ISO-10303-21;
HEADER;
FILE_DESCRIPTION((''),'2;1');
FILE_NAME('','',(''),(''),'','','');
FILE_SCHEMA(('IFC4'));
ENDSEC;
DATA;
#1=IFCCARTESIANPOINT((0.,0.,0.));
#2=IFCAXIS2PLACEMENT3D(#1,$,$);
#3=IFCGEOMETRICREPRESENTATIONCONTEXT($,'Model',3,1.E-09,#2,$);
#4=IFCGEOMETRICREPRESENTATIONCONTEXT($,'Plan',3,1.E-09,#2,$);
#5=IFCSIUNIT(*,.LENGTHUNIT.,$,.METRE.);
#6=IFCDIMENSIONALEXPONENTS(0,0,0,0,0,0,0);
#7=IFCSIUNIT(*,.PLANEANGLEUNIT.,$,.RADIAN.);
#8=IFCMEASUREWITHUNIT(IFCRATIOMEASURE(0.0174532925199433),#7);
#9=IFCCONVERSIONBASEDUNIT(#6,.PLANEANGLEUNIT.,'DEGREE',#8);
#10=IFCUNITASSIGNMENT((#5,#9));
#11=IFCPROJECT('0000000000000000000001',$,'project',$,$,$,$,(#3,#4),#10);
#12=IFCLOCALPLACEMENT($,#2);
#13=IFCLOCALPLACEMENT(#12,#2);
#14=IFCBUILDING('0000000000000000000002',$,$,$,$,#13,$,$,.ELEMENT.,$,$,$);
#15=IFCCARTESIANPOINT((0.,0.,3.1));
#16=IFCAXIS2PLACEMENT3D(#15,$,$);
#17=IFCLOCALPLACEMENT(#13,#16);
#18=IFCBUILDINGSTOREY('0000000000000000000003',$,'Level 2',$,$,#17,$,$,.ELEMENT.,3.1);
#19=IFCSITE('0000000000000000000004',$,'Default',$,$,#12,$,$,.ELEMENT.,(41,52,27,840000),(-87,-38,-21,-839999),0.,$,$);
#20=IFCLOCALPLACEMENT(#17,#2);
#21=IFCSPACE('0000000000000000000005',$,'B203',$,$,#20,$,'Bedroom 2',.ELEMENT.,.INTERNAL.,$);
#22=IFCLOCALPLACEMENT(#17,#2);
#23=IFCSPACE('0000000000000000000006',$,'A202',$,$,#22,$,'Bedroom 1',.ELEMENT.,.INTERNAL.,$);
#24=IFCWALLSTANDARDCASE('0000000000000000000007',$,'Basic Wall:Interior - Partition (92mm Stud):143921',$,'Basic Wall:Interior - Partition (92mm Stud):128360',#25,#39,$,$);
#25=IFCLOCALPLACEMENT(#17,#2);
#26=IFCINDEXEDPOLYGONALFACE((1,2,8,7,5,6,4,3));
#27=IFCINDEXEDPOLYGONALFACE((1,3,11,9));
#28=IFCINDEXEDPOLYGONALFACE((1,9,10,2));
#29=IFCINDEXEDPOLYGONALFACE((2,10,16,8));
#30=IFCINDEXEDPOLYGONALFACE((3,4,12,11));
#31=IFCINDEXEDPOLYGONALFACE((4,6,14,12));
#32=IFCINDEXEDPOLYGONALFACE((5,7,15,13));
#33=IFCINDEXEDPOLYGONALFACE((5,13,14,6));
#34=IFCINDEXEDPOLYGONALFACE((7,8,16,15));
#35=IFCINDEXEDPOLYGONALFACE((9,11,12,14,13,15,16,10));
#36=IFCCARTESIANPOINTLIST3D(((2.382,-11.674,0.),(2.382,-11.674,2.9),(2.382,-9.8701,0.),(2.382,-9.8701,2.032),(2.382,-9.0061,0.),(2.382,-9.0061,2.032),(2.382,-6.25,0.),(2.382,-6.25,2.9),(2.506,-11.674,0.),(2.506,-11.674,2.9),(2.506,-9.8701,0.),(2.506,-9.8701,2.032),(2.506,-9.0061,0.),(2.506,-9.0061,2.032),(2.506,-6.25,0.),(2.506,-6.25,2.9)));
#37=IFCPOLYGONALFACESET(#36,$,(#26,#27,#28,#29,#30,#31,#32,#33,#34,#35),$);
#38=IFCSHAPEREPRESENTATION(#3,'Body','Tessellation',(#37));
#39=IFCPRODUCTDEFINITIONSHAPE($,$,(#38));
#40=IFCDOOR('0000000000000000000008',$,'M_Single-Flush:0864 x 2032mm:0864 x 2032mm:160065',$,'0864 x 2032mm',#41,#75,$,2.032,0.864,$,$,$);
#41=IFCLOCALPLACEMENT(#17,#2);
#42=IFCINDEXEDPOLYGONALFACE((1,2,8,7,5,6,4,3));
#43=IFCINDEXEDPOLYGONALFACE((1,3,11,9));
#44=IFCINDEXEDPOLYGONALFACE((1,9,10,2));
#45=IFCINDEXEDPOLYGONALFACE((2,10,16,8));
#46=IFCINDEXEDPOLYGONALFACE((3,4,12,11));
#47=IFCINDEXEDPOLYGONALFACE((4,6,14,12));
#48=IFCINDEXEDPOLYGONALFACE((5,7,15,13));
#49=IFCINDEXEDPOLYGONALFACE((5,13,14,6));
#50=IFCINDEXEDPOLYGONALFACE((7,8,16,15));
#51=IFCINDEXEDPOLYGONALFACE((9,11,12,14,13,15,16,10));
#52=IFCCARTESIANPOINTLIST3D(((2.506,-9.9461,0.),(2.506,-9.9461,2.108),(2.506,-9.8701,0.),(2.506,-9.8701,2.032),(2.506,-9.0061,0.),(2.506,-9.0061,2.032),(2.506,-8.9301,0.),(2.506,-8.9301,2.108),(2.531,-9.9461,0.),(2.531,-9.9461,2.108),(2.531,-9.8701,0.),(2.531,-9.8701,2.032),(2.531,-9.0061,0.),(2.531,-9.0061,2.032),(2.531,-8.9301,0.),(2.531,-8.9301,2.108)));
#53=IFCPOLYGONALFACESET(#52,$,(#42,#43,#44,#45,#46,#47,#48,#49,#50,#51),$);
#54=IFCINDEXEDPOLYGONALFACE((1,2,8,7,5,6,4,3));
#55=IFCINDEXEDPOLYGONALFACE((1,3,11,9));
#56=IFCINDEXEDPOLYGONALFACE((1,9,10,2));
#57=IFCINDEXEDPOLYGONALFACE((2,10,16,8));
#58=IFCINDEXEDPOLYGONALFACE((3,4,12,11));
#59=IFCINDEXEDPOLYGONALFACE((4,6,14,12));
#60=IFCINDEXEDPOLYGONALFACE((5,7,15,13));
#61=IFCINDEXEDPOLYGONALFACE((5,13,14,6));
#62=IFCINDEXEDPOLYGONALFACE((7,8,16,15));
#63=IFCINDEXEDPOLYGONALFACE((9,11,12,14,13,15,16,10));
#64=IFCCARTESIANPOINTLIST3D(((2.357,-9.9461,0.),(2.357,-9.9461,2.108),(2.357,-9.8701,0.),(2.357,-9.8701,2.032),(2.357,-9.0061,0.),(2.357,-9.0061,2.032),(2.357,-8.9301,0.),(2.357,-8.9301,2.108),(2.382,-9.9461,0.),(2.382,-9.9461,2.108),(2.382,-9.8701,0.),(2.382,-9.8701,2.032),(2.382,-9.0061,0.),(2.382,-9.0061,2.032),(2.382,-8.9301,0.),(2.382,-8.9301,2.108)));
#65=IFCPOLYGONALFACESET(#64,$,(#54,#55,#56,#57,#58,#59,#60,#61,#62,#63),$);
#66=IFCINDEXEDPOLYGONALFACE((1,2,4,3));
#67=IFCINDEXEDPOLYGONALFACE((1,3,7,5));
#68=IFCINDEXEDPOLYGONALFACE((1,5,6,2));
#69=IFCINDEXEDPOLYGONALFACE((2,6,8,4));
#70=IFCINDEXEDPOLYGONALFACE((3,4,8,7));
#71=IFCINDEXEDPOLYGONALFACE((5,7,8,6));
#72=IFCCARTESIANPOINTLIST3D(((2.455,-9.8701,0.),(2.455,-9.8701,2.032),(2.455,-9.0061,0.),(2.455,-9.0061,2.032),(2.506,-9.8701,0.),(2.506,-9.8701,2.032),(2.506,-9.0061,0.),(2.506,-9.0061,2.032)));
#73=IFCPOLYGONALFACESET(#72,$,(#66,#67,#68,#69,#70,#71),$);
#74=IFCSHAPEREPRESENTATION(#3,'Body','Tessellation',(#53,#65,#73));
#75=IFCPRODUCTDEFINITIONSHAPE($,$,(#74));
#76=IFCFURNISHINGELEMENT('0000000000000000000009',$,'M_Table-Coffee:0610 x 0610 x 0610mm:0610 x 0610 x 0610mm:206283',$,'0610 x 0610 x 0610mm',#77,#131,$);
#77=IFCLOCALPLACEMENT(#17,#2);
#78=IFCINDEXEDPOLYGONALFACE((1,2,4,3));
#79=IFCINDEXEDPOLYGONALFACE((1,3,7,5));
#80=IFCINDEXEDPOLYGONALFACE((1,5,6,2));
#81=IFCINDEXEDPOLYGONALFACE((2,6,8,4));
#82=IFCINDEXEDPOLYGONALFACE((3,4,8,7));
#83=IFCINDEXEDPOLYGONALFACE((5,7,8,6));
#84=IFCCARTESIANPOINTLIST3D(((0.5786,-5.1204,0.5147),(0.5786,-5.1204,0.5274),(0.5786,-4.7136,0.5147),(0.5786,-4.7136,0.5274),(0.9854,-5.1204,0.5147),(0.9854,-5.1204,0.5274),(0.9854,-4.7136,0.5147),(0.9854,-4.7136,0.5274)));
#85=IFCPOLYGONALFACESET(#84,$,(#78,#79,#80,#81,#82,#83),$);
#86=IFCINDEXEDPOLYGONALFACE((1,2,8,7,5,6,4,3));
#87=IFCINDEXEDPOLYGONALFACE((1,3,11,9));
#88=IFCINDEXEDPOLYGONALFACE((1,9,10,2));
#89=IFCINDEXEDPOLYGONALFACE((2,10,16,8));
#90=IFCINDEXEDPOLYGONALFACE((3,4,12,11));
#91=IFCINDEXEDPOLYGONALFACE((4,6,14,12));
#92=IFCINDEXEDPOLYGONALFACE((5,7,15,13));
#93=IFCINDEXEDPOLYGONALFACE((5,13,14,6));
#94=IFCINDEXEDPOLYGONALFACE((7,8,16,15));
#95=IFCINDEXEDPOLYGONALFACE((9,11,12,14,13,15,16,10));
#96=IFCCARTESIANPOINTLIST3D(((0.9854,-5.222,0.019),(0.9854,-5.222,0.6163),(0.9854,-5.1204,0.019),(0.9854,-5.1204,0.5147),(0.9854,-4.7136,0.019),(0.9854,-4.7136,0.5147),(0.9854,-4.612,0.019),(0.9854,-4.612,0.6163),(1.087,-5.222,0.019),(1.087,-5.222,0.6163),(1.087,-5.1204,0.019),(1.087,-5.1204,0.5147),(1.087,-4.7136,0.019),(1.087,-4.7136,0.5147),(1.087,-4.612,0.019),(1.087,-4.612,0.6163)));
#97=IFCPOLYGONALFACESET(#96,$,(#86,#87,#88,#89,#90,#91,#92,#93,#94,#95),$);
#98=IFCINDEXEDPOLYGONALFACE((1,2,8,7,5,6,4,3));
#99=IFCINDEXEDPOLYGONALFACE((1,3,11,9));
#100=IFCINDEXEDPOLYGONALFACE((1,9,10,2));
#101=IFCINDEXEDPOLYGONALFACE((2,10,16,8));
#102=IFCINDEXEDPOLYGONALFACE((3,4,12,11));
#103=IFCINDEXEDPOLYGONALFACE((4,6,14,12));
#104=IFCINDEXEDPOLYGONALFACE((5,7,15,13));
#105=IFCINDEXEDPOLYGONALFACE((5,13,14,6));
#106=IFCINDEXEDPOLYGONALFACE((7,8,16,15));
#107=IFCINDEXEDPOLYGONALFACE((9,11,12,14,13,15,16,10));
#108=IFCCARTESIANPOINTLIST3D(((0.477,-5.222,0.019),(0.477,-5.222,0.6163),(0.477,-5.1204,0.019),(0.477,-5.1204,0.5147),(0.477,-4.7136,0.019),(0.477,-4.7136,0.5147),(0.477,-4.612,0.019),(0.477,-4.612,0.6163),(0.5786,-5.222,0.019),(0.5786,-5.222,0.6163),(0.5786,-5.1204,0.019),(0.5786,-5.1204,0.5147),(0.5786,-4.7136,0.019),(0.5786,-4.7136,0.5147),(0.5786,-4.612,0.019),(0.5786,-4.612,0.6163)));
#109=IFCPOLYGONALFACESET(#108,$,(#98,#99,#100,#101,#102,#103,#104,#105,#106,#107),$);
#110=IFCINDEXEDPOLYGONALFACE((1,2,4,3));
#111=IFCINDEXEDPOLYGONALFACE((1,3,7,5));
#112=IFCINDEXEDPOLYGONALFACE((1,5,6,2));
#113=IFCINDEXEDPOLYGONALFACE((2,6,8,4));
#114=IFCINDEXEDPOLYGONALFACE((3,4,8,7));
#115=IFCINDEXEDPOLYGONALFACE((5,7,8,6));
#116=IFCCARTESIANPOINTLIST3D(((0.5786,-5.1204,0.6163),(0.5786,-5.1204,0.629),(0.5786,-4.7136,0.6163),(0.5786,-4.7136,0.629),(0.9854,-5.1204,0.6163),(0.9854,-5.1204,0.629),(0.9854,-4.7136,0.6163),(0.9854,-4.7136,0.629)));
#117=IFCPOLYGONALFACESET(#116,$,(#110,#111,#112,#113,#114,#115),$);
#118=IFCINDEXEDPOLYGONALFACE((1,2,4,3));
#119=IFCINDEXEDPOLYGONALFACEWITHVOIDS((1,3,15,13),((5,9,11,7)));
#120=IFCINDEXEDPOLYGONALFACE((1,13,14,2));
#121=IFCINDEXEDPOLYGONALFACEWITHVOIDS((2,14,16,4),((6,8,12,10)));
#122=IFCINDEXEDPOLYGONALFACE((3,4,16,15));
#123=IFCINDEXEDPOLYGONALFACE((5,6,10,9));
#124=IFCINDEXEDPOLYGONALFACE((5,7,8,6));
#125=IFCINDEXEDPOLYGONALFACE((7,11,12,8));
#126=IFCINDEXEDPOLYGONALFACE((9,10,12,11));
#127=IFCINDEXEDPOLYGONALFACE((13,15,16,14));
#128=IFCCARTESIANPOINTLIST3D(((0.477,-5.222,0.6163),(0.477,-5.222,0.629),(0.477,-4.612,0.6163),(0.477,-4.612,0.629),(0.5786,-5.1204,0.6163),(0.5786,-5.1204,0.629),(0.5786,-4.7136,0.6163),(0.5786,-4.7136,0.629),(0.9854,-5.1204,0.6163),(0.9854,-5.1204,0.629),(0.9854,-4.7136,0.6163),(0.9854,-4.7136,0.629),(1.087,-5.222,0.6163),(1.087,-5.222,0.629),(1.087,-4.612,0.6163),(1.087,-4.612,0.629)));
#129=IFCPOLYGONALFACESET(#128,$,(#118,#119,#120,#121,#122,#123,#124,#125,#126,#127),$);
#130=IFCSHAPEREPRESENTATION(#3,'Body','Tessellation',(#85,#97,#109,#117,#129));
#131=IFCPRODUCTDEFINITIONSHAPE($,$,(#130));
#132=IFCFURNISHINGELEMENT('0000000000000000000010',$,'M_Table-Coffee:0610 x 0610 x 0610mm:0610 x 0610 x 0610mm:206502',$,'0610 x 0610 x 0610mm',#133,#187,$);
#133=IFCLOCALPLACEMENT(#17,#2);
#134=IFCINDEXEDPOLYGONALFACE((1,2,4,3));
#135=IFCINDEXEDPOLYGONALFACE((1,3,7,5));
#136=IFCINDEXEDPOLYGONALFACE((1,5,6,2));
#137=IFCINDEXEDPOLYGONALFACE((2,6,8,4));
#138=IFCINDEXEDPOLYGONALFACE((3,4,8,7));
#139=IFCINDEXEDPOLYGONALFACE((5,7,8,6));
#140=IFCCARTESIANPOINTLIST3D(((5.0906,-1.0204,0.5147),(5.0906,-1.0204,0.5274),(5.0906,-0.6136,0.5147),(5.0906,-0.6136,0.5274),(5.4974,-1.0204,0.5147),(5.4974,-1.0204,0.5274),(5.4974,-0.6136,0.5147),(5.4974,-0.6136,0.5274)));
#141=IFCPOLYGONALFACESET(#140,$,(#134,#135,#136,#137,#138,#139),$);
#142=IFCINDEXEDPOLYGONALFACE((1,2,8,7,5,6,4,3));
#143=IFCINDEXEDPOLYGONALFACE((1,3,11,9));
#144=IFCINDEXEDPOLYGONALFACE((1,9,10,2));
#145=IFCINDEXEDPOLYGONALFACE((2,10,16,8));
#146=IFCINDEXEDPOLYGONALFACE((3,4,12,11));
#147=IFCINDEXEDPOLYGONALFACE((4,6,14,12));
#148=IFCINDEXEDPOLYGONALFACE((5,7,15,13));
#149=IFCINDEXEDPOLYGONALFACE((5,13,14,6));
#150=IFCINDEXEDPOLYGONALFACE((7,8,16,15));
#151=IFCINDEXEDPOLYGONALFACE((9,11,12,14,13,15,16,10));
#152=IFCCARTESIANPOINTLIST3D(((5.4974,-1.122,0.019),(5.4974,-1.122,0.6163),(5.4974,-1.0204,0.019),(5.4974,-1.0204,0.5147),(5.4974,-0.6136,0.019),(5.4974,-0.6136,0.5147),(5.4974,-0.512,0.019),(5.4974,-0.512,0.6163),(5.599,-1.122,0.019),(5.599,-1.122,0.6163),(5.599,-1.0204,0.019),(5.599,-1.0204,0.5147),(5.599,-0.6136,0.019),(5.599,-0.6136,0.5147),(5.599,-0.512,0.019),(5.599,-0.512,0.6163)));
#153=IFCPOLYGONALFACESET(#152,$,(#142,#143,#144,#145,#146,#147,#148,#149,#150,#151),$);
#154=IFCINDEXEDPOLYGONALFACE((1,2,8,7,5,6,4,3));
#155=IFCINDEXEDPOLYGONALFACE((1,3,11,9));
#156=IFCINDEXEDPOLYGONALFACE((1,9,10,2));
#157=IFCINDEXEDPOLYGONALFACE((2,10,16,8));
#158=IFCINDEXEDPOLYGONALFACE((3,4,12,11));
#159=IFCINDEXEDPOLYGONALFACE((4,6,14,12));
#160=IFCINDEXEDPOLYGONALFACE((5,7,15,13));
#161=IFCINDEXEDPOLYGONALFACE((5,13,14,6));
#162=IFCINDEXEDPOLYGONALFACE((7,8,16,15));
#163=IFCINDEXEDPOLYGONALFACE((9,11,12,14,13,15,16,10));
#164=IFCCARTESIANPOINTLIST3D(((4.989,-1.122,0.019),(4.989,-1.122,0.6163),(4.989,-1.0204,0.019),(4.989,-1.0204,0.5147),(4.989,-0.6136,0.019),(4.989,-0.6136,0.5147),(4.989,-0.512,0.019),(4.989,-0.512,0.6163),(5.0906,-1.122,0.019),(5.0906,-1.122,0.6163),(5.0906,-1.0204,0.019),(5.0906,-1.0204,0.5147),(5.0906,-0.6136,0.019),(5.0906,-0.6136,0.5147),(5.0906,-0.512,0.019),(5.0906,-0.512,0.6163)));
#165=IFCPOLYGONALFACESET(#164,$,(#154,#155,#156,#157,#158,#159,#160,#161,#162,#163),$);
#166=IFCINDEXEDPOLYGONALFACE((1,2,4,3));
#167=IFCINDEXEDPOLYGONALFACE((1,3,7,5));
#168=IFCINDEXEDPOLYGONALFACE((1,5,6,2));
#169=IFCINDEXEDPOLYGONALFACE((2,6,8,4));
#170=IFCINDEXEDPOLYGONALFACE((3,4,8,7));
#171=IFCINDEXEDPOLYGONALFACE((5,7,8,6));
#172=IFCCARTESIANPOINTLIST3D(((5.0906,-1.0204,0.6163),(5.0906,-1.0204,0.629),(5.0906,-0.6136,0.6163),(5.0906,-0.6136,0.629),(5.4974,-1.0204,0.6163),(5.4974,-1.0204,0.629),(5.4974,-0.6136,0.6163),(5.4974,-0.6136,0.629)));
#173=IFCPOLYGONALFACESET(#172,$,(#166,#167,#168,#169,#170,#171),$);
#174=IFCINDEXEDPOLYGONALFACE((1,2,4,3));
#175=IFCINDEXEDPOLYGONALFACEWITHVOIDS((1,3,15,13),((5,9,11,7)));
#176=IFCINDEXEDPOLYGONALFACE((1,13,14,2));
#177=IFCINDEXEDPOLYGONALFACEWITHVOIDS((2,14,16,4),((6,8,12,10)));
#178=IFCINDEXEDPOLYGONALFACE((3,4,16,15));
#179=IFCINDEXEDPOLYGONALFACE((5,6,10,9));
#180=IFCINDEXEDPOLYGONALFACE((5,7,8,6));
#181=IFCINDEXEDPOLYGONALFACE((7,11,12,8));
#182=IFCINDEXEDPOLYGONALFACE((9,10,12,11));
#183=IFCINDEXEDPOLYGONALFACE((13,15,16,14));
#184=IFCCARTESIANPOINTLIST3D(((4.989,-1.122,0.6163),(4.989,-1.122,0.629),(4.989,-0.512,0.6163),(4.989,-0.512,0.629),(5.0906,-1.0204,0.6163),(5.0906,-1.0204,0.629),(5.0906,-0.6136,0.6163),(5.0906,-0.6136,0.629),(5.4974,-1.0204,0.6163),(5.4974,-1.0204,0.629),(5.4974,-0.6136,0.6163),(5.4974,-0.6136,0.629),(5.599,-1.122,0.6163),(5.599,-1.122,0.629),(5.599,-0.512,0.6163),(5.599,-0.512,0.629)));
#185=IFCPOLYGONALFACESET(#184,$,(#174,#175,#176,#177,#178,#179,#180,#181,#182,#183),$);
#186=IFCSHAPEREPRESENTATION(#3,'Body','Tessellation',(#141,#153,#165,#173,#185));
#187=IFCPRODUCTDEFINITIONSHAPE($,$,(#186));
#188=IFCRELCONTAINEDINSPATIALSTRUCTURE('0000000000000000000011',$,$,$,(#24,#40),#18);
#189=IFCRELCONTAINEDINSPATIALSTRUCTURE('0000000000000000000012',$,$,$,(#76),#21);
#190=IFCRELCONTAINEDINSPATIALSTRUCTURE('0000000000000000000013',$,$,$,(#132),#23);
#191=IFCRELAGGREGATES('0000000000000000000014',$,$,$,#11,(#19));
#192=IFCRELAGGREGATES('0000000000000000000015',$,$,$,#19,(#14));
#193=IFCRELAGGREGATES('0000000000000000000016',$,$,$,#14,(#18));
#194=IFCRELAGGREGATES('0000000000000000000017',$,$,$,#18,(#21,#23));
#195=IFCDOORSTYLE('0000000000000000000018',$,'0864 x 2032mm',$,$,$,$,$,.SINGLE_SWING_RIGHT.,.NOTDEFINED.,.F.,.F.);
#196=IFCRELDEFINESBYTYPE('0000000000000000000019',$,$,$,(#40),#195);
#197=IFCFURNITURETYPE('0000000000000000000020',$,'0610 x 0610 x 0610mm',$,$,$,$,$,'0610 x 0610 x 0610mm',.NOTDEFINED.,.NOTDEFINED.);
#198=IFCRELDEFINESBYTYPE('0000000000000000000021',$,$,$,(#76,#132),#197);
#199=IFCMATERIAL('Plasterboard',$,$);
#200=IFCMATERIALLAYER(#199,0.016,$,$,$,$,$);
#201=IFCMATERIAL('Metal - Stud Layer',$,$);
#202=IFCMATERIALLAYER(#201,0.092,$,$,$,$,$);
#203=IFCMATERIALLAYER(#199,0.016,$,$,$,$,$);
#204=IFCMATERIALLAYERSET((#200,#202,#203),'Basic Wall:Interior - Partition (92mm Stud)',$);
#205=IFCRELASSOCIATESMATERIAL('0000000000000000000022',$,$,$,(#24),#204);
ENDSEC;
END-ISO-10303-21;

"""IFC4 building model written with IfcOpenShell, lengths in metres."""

from ifc_helpers import new_model, entity, si_unit, converted_unit, frame, frame_2d, origin, origin_2d_with_axis, place, context, project, spatial, polyline, rectangle, outline, extrude, source, transform, mapped, material, layer, layer_set, layer_usage, type_object, type_shapes, element, fill, save


model = new_model("IFC4")

# Units and contexts
model_context = context("Model", 3, precision=1e-09, world=origin())
plan_context = context("Plan", 3, precision=1e-09, world=origin())
ifc_project = project(units=[si_unit("LENGTHUNIT", "METRE"), converted_unit("PLANEANGLEUNIT", "DEGREE", entity("IfcRatioMeasure", 0.0174532925199433), si_unit("PLANEANGLEUNIT", "RADIAN"), dimensions=[0, 0, 0, 0, 0, 0, 0])], contexts=[model_context, plan_context])

# Site, building, storey
site_placement = place(None, origin())
site = spatial("IfcSite", under=ifc_project, at=site_placement, Name="Default", CompositionType="ELEMENT", RefLatitude=(41, 52, 27, 840000), RefLongitude=(-87, -38, -21, -839999), RefElevation=0.0)
building_placement = place(site_placement, origin())
building = spatial("IfcBuilding", under=site, at=building_placement, CompositionType="ELEMENT")
storey_placement = place(building_placement, frame((0.0, 0.0, 3.1)))
storey = spatial("IfcBuildingStorey", under=building, at=storey_placement, Name="Level 2", CompositionType="ELEMENT", Elevation=3.1)

# Shared definitions
ifc_material_1 = material(Name="Metal - Stud Layer")
ifc_material_2 = material(Name="Plasterboard")

# Wall, opening, door
ifc_layer_1 = layer(ifc_material_2, 0.016)
ifc_layer_2 = layer(ifc_material_1, 0.092)
ifc_layer_3 = layer(ifc_material_2, 0.016)
ifc_layer_set_1 = layer_set([ifc_layer_1, ifc_layer_2, ifc_layer_3], Name="Basic Wall:Interior - Partition (92mm Stud)")
ifc_layer_usage_1 = layer_usage(ifc_layer_set_1, "AXIS2", "NEGATIVE", 0.062)
wall_1_placement = place(storey_placement, frame((2.444, -6.25, 0.0), z_axis=(0.0, 0.0, 1.0), x_axis=(0.0, -1.0, 0.0)))
wall_1 = element("IfcWallStandardCase", 1, at=wall_1_placement, inside=storey, material=ifc_layer_usage_1, Name="Basic Wall:Interior - Partition (92mm Stud):143921", ObjectType="Basic Wall:Interior - Partition (92mm Stud):128360", context=model_context, shape_type="SweptSolid", body=[
    extrude(rectangle(XDim=5.424, YDim=0.124, at=frame_2d((2.712, 0.0), x_axis=(-1.0, 0.0))), origin(), (0.0, 0.0, 1.0), 2.9),
])
opening_1_placement = place(wall_1_placement, frame((2.7561, -0.062, 0.0)))
opening_1 = element("IfcOpeningElement", 2, at=opening_1_placement, cuts=wall_1, ObjectType="Opening", context=model_context, shape_type="SweptSolid", body=[
    extrude(rectangle(XDim=0.864, YDim=2.032, at=frame_2d((1.016, 0.432), x_axis=(0.0, 1.0))), frame((0.0, 0.0, 0.0), z_axis=(0.0, 1.0, 0.0), x_axis=(0.0, 0.0, 1.0)), (0.0, 0.0, 1.0), 0.124),
])
door_style_1 = type_object("IfcDoorStyle", Name="0864 x 2032mm", ConstructionType="NOTDEFINED", OperationType="SINGLE_SWING_RIGHT", ParameterTakesPrecedence=False, Sizeable=False)
shared_shape_1 = source(origin(), model_context, "Body", "SweptSolid", [
    extrude(outline(polyline([(-0.508, -1.073), (0.508, -1.073), (0.508, 1.035), (0.432, 1.035), (0.432, -0.997), (-0.432, -0.997), (-0.432, 1.035), (-0.508, 1.035), (-0.508, -1.073)])), frame((0.432, 0.124, 1.035), z_axis=(0.0, 1.0, 0.0), x_axis=(1.0, 0.0, 0.0)), (0.0, 0.0, 1.0), 0.025),
    extrude(outline(polyline([(-1.073, -0.508), (1.035, -0.508), (1.035, -0.432), (-0.997, -0.432), (-0.997, 0.432), (1.035, 0.432), (1.035, 0.508), (-1.073, 0.508), (-1.073, -0.508)])), frame((0.432, -0.025, 1.035), z_axis=(0.0, 1.0, 0.0), x_axis=(0.0, 0.0, -1.0)), (0.0, 0.0, 1.0), 0.025),
    extrude(rectangle(XDim=0.051, YDim=0.864, at=origin_2d_with_axis()), frame((0.432, 0.0985, 0.0), z_axis=(0.0, 0.0, 1.0), x_axis=(0.0, 1.0, 0.0)), (0.0, 0.0, 1.0), 2.032),
])
type_shapes(door_style_1, [shared_shape_1])
door_1_placement = place(opening_1_placement, origin())
door_1 = element("IfcDoor", 3, at=door_1_placement, inside=storey, type_object=door_style_1, Name="M_Single-Flush:0864 x 2032mm:0864 x 2032mm:160065", ObjectType="0864 x 2032mm", OverallHeight=2.032, OverallWidth=0.864, context=model_context, shape_type="MappedRepresentation", body=[
    mapped(shared_shape_1, transform((0.0, 0.0, 0.0), scale=1.0)),
])
fill(opening_1, door_1)

# Shared definitions
space_1_placement = place(storey_placement, origin())
space_1 = spatial("IfcSpace", under=storey, at=space_1_placement, Name="B203", LongName="Bedroom 2", CompositionType="ELEMENT", PredefinedType="INTERNAL")

# Furnishing element
furniture_type = type_object("IfcFurnitureType", Name="0610 x 0610 x 0610mm", ElementType="0610 x 0610 x 0610mm", AssemblyPlace="NOTDEFINED")
shared_shape_2 = source(origin(), model_context, "Body", "SweptSolid", [
    extrude(rectangle(XDim=0.4068, YDim=0.4068, at=origin_2d_with_axis()), frame((0.0183, 0.0952, 0.4957), z_axis=(0.0, 0.0, 1.0), x_axis=(-1.0, 0.0, 0.0)), (0.0, 0.0, 1.0), 0.0127),
    extrude(outline(polyline([(-0.2732, -0.305), (0.324, -0.305), (0.324, 0.305), (-0.2732, 0.305), (-0.2732, 0.2034), (0.2225, 0.2034), (0.2225, -0.2034), (-0.2732, -0.2034), (-0.2732, -0.305)])), frame((0.2217, 0.0952, 0.2732), z_axis=(1.0, 0.0, 0.0), x_axis=(0.0, 0.0, 1.0)), (0.0, 0.0, 1.0), 0.1016),
    extrude(outline(polyline([(-0.305, -0.3241), (0.305, -0.3241), (0.305, 0.2733), (0.2034, 0.2733), (0.2034, -0.2224), (-0.2034, -0.2224), (-0.2034, 0.2733), (-0.305, 0.2733), (-0.305, -0.3241)])), frame((-0.2867, 0.0952, 0.2733), z_axis=(1.0, 0.0, 0.0), x_axis=(0.0, -1.0, 0.0)), (0.0, 0.0, 1.0), 0.1016),
    extrude(rectangle(XDim=0.4068, YDim=0.4068, at=origin_2d_with_axis()), frame((0.0183, 0.0952, 0.5973), z_axis=(0.0, 0.0, 1.0), x_axis=(-1.0, 0.0, 0.0)), (0.0, 0.0, 1.0), 0.0127),
    extrude(outline(polyline([(-0.305, -0.305), (0.305, -0.305), (0.305, 0.305), (-0.305, 0.305), (-0.305, -0.305)]), holes=[polyline([(-0.2034, -0.2034), (-0.2034, 0.2034), (0.2034, 0.2034), (0.2034, -0.2034), (-0.2034, -0.2034)])]), frame((0.0183, 0.0952, 0.5973), z_axis=(0.0, 0.0, 1.0), x_axis=(-1.0, 0.0, 0.0)), (0.0, 0.0, 1.0), 0.0127),
])
type_shapes(furniture_type, [shared_shape_2])
furnishing_1_placement = place(space_1_placement, frame((0.7637, -5.0122, 0.019)))
element("IfcFurnishingElement", 4, at=furnishing_1_placement, inside=space_1, type_object=furniture_type, Name="M_Table-Coffee:0610 x 0610 x 0610mm:0610 x 0610 x 0610mm:206283", ObjectType="0610 x 0610 x 0610mm", context=model_context, shape_type="MappedRepresentation", body=[
    mapped(shared_shape_2, transform((0.0, 0.0, 0.0), scale=1.0)),
])

# Shared definitions
space_2_placement = place(storey_placement, origin())
space_2 = spatial("IfcSpace", under=storey, at=space_2_placement, Name="A202", LongName="Bedroom 1", CompositionType="ELEMENT", PredefinedType="INTERNAL")

# Furnishing element
furnishing_2_placement = place(space_2_placement, frame((5.2757, -0.9122, 0.019)))
element("IfcFurnishingElement", 5, at=furnishing_2_placement, inside=space_2, type_object=furniture_type, Name="M_Table-Coffee:0610 x 0610 x 0610mm:0610 x 0610 x 0610mm:206502", ObjectType="0610 x 0610 x 0610mm", context=model_context, shape_type="MappedRepresentation", body=[
    mapped(shared_shape_2, transform((0.0, 0.0, 0.0), scale=1.0)),
])

save(model, "model.ifc")
